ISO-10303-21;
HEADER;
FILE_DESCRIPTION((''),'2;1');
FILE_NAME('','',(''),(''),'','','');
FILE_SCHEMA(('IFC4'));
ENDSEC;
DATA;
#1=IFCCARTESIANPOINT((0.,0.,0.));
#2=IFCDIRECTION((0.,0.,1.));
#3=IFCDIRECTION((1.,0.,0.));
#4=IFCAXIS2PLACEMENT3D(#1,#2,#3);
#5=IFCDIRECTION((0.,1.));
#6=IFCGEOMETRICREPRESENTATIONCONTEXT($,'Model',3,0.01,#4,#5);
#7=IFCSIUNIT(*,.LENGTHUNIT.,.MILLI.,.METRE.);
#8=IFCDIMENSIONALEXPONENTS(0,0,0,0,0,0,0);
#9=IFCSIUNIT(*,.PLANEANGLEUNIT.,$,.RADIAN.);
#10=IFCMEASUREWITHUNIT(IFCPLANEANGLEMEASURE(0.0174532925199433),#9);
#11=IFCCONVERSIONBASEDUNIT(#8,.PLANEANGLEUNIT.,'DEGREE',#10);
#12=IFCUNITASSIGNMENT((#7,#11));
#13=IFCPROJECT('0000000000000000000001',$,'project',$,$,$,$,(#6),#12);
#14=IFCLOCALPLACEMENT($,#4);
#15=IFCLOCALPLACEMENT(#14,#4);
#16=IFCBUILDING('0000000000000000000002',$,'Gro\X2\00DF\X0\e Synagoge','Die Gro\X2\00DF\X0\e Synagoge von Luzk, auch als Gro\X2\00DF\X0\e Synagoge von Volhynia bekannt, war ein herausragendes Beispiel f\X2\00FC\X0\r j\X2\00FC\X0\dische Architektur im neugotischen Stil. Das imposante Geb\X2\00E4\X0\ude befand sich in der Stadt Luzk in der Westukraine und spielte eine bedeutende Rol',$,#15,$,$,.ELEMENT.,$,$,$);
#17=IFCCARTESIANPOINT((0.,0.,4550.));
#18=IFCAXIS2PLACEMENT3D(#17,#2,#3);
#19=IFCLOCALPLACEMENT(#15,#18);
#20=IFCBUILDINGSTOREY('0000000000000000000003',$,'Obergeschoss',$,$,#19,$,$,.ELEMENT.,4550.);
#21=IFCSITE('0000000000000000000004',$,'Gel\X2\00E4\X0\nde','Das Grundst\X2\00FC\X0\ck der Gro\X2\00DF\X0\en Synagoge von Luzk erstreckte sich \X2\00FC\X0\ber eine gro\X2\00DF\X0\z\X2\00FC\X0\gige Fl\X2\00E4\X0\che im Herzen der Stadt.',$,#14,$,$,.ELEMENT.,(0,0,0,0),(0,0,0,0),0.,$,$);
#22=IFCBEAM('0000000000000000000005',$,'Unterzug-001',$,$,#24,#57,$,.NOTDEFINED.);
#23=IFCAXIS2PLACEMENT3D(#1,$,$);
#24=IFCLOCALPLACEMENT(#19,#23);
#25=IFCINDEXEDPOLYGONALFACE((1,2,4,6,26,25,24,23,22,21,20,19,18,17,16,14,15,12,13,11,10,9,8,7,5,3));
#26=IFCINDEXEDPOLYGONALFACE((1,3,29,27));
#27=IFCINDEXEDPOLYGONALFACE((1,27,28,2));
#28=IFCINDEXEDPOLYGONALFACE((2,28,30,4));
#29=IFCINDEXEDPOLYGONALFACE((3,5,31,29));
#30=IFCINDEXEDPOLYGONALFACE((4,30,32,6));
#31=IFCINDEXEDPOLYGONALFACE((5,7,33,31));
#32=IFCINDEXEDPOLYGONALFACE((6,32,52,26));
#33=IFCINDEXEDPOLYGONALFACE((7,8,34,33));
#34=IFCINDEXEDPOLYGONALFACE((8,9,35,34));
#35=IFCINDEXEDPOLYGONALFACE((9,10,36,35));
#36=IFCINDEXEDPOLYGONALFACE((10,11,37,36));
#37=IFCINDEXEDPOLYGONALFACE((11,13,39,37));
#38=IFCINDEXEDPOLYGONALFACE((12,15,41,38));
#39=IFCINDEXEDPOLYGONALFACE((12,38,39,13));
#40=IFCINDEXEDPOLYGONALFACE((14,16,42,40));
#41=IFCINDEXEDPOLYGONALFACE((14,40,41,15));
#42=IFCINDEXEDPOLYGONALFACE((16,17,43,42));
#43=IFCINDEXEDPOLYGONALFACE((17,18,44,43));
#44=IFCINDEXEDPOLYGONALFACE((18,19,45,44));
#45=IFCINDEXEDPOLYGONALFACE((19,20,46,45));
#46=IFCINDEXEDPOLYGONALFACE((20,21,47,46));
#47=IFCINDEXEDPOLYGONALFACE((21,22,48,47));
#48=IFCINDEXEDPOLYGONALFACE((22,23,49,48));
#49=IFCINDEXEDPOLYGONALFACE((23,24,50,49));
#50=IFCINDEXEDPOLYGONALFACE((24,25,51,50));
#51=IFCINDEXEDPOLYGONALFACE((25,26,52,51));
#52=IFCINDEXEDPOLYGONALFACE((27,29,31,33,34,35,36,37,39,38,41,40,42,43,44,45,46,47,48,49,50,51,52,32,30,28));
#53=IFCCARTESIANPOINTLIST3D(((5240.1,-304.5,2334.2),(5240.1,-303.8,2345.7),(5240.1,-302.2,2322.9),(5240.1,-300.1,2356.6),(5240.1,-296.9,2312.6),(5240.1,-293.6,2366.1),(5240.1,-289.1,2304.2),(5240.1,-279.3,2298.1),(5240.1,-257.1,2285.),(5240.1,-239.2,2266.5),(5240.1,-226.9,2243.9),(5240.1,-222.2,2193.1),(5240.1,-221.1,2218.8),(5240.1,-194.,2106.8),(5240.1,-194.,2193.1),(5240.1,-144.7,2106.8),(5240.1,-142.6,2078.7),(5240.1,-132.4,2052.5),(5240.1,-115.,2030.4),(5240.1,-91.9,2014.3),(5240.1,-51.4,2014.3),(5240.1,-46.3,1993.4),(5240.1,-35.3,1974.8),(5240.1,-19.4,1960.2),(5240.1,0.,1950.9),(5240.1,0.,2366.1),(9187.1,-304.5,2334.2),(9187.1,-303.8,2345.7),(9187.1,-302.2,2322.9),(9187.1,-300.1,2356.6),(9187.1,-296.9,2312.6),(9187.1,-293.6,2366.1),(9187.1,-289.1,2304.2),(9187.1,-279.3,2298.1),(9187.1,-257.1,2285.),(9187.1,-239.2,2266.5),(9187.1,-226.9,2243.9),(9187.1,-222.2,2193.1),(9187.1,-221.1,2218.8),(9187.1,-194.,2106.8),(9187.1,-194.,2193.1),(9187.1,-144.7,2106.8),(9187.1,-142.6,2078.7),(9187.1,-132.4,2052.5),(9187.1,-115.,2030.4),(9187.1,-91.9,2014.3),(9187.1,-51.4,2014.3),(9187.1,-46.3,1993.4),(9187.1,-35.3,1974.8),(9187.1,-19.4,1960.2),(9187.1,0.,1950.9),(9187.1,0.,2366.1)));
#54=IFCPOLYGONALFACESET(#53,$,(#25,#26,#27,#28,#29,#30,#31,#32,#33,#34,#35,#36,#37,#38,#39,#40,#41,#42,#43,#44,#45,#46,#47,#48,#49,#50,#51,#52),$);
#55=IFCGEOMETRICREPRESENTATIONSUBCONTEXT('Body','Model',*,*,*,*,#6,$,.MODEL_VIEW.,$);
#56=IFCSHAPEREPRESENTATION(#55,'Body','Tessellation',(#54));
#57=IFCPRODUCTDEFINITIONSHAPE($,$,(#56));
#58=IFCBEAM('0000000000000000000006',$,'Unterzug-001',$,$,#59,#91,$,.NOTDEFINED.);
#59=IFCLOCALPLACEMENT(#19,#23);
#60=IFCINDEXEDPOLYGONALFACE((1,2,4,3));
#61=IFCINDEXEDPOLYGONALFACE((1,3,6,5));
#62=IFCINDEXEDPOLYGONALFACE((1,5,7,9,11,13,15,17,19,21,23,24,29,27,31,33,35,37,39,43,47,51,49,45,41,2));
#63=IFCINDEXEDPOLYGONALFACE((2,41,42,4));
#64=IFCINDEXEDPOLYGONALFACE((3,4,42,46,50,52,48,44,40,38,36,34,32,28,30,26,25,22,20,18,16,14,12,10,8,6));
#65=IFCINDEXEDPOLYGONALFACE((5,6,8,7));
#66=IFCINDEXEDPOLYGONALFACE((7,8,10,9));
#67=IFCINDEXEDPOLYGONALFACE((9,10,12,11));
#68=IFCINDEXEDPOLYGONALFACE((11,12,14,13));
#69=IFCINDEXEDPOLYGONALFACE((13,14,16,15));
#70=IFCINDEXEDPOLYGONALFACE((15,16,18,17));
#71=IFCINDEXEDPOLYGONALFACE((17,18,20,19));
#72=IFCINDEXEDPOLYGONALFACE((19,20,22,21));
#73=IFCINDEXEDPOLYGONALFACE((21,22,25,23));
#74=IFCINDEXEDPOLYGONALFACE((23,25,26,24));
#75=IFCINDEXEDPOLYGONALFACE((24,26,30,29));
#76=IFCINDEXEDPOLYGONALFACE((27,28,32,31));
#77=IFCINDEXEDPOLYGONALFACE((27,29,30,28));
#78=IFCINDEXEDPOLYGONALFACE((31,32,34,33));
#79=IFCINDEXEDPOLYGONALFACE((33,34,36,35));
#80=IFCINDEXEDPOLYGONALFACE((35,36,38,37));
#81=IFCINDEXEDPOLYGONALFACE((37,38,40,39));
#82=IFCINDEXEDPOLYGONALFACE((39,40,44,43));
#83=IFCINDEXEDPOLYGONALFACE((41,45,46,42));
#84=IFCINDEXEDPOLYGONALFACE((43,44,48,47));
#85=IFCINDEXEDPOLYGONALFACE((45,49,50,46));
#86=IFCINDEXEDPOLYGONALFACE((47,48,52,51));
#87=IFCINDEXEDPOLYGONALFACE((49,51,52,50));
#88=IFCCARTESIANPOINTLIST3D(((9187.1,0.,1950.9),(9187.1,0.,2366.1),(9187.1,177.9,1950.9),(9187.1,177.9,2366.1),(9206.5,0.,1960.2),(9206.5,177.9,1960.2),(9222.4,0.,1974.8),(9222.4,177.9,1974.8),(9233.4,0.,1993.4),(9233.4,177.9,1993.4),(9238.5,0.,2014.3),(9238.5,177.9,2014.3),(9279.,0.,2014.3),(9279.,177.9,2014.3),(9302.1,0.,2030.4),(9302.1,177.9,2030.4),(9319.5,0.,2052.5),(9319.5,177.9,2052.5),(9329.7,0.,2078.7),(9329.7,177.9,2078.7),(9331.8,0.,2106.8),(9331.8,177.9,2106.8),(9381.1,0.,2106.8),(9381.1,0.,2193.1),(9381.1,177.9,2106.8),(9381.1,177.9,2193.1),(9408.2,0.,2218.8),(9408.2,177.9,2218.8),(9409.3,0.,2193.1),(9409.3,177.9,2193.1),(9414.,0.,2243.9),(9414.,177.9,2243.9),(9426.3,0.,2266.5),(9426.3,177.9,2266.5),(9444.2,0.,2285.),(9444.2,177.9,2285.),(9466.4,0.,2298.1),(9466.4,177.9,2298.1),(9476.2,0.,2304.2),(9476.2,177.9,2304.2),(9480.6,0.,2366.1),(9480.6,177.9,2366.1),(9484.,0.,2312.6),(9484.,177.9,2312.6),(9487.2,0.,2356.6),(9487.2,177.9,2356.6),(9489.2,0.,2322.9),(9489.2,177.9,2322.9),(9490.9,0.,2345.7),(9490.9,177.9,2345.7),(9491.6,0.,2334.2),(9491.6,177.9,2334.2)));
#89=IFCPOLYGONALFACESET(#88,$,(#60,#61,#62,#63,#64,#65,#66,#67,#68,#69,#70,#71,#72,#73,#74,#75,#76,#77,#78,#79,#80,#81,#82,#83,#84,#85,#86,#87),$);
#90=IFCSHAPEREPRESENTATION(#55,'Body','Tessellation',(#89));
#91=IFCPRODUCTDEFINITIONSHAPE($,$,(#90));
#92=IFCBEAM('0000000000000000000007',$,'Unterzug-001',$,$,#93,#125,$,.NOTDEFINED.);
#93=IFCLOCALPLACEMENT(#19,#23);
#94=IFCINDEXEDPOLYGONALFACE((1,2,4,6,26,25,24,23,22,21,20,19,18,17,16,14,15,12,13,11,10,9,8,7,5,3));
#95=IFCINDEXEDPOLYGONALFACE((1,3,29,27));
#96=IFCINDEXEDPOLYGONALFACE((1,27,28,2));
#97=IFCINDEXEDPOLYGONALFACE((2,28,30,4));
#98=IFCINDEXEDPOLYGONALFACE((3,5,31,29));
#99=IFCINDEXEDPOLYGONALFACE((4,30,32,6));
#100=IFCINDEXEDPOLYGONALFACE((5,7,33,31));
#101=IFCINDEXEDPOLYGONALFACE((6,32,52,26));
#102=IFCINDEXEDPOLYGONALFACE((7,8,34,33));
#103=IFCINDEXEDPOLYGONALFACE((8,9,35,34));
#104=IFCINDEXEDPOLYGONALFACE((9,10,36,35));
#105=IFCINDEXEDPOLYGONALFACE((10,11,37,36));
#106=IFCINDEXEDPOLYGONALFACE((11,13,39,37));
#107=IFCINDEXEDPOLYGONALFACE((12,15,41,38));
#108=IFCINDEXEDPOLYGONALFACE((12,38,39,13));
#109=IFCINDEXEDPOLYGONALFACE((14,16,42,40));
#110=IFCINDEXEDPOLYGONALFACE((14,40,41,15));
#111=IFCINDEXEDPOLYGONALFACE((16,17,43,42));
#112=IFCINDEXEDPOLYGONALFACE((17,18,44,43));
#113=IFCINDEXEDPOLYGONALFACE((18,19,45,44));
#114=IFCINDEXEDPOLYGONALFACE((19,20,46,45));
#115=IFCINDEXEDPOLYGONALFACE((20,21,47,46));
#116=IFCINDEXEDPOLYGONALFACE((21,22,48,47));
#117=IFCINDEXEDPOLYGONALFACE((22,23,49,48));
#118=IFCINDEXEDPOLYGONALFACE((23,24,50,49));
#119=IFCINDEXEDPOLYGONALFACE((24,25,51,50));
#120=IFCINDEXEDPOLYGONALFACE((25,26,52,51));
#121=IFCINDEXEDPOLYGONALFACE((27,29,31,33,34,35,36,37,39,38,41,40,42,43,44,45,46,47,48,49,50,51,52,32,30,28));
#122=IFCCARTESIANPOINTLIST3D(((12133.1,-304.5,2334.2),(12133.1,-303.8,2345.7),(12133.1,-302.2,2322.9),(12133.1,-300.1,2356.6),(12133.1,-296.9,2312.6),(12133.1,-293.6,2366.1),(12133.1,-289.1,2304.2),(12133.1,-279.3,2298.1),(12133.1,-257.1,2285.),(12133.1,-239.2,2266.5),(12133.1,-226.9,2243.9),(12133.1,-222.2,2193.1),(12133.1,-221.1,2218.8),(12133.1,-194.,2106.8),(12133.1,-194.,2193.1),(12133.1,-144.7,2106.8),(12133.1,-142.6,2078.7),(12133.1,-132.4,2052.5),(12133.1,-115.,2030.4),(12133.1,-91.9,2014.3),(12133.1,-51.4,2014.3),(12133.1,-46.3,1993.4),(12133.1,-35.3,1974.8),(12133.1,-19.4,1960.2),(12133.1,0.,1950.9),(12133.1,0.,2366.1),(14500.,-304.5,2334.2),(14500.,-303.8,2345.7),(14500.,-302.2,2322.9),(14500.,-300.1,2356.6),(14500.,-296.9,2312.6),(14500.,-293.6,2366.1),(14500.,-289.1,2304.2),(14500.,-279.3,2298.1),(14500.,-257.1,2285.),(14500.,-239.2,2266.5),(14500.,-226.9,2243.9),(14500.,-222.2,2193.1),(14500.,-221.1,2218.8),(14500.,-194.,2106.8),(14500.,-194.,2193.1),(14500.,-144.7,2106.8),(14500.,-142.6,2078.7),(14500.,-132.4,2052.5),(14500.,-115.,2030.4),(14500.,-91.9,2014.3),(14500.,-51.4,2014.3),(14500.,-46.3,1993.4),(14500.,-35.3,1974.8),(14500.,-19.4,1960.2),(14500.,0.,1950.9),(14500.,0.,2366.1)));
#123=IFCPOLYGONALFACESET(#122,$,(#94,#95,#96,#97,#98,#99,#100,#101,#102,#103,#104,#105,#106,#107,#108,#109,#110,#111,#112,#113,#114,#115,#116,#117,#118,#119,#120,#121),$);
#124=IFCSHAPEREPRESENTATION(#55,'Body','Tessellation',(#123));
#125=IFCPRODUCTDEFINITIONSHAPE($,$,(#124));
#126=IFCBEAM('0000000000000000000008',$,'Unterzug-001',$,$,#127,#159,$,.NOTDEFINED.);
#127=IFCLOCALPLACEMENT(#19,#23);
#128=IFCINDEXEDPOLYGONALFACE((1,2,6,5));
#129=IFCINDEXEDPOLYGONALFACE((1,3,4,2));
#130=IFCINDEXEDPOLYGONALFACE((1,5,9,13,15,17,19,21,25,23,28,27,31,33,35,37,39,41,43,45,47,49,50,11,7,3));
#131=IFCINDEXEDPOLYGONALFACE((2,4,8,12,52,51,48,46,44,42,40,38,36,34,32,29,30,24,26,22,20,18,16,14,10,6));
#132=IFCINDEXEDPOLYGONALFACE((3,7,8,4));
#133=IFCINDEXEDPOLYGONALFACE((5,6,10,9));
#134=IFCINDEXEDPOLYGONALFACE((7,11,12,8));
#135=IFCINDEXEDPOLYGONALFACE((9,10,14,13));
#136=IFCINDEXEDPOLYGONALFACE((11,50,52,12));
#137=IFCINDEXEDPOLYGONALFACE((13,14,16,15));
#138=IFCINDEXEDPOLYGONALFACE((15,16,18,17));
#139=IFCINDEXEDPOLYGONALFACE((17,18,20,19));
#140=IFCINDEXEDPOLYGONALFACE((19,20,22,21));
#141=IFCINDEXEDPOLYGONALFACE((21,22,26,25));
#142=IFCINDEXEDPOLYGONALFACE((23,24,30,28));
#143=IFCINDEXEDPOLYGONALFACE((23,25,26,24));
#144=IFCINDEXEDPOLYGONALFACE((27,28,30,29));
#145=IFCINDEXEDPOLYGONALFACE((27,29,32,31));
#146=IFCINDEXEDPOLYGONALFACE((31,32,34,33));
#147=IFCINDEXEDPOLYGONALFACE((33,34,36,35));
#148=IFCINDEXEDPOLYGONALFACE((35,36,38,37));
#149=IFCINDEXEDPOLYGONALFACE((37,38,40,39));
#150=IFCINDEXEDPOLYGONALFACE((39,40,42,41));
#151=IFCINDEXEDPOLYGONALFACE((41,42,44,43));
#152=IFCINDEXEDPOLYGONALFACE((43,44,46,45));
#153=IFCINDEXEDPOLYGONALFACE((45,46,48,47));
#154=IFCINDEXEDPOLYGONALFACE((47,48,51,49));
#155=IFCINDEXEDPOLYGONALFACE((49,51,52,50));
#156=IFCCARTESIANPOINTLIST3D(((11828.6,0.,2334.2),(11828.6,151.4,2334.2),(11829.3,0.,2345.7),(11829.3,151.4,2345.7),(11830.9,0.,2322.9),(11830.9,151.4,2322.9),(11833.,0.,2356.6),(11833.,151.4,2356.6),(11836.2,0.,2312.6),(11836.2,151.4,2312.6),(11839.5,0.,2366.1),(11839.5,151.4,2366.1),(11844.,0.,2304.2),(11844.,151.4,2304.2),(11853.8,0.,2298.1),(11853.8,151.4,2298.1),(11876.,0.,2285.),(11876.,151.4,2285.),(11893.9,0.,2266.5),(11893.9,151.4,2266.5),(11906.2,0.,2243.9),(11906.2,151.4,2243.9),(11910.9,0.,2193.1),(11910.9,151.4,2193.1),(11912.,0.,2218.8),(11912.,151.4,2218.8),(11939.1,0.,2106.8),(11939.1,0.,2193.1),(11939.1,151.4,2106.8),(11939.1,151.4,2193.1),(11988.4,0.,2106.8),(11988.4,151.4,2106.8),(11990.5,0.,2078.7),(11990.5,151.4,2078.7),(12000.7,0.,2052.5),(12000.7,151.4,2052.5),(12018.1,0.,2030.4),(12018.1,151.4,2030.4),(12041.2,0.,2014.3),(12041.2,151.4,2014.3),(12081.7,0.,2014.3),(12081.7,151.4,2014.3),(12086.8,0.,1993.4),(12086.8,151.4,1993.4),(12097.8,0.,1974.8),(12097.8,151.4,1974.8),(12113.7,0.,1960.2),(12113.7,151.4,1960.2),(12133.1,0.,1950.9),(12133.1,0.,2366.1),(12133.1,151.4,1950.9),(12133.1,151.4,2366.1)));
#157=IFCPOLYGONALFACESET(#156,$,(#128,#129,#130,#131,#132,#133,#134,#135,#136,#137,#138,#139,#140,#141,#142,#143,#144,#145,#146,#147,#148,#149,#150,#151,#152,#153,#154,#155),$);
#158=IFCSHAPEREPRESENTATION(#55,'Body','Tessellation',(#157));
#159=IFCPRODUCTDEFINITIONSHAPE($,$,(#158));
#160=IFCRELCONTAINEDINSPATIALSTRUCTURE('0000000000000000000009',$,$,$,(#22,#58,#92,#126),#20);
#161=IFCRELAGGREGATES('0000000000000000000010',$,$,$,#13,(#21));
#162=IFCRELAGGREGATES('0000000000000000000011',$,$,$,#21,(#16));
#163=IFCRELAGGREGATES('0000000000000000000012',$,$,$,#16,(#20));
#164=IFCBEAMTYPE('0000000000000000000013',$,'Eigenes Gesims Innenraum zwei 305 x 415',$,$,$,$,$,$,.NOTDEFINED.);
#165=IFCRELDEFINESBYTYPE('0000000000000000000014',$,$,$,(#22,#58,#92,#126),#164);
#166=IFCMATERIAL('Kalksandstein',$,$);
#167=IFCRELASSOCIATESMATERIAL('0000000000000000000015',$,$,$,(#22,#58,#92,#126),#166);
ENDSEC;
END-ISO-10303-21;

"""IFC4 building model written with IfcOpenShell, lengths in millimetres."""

from ifc_helpers import new_model, entity, si_unit, converted_unit, direction, frame, origin_with_axes, place, context, subcontext, project, spatial, line, arc, indexed_curve, outline, extrude, material, material_profile, profile_set, type_object, element, save


model = new_model("IFC4")

# Units and contexts
model_context = context("Model", 3, precision=0.01, world=origin_with_axes(), true_north=direction((0.0, 1.0)))
body_context = subcontext(model_context, "Body", "Model", "MODEL_VIEW")
ifc_project = project(units=[si_unit("LENGTHUNIT", "METRE", prefix="MILLI"), converted_unit("PLANEANGLEUNIT", "DEGREE", entity("IfcPlaneAngleMeasure", 0.0174532925199433), si_unit("PLANEANGLEUNIT", "RADIAN"), dimensions=[0, 0, 0, 0, 0, 0, 0])], contexts=[model_context])

# Site, building, storey
site_placement = place(None, origin_with_axes())
site = spatial("IfcSite", under=ifc_project, at=site_placement, Name="Gelände", Description="Das Grundstück der Großen Synagoge von Luzk erstreckte sich über eine großzügige Fläche im Herzen der Stadt.", CompositionType="ELEMENT", RefLatitude=(0, 0, 0, 0), RefLongitude=(0, 0, 0, 0), RefElevation=0.0)
building_placement = place(site_placement, origin_with_axes())
building = spatial("IfcBuilding", under=site, at=building_placement, Name="Große Synagoge", Description="Die Große Synagoge von Luzk, auch als Große Synagoge von Volhynia bekannt, war ein herausragendes Beispiel für jüdische Architektur im neugotischen Stil. Das imposante Gebäude befand sich in der Stadt Luzk in der Westukraine und spielte eine bedeutende Rol", CompositionType="ELEMENT")
storey_placement = place(building_placement, frame((0.0, 0.0, 4550.0), z_axis=(0.0, 0.0, 1.0), x_axis=(1.0, 0.0, 0.0)))
storey = spatial("IfcBuildingStorey", under=building, at=storey_placement, Name="Obergeschoss", CompositionType="ELEMENT", Elevation=4550.0)

# Beams
ifc_material_1 = material(Name="Kalksandstein")
ifc_material_profile_1 = material_profile(ifc_material_1, outline(indexed_curve([(194.0, -173.0), (222.2, -173.0), (232.3, -110.5), (279.3, -68.0), (303.7, -37.6), (293.6, 0.0), (0.0, 0.0), (0.0, -415.2), (35.3, -391.3), (51.4, -351.7), (91.9, -351.7), (132.4, -313.6), (144.7, -259.3), (194.0, -259.3)], segments=[line(1, 2), arc(2, 3, 4), arc(4, 5, 6), line(6, 7, 8), arc(8, 9, 10), line(10, 11), arc(11, 12, 13), line(13, 14, 1)])), Name="Kalksandstein")
ifc_profile_set_1 = profile_set([ifc_material_profile_1], Name="Eigenes Gesims Innenraum zwei")
beam_type_1 = type_object("IfcBeamType", Name="Eigenes Gesims Innenraum zwei 305 x 415", PredefinedType="NOTDEFINED")
beam_1_placement = place(storey_placement, frame((9187.1, 0.0, 2366.1), z_axis=(0.0, 0.0, 1.0), x_axis=(0.0, 1.0, 0.0)))
element("IfcBeam", 1, at=beam_1_placement, inside=storey, type_object=beam_type_1, material=ifc_profile_set_1, Name="Unterzug-001", PredefinedType="NOTDEFINED", context=body_context, shape_type="SweptSolid", body=[
    extrude(outline(indexed_curve([(194.0, -173.0), (222.2, -173.0), (232.3, -110.5), (279.3, -68.0), (303.7, -37.6), (293.6, 0.0), (0.0, 0.0), (0.0, -415.2), (35.3, -391.3), (51.4, -351.7), (91.9, -351.7), (132.4, -313.6), (144.7, -259.3), (194.0, -259.3)], segments=[line(1, 2), arc(2, 3, 4), arc(4, 5, 6), line(6, 7, 8), arc(8, 9, 10), line(10, 11), arc(11, 12, 13), line(13, 14, 1)])), frame((0.0, 3947.0, 0.0), z_axis=(0.0, 1.0, 0.0), x_axis=(-1.0, 0.0, 0.0)), (0.0, 0.0, -1.0), 3947.0),
])
beam_2_placement = place(storey_placement, frame((9187.1, 177.9, 2366.1), z_axis=(0.0, 0.0, 1.0), x_axis=(-1.0, 0.0, 0.0)))
element("IfcBeam", 2, at=beam_2_placement, inside=storey, type_object=beam_type_1, material=ifc_profile_set_1, Name="Unterzug-001", PredefinedType="NOTDEFINED", context=body_context, shape_type="SweptSolid", body=[
    extrude(outline(indexed_curve([(194.0, -173.0), (222.2, -173.0), (232.3, -110.5), (279.3, -68.0), (303.7, -37.6), (293.6, 0.0), (0.0, 0.0), (0.0, -415.2), (35.3, -391.3), (51.4, -351.7), (91.9, -351.7), (132.4, -313.6), (144.7, -259.3), (194.0, -259.3)], segments=[line(1, 2), arc(2, 3, 4), arc(4, 5, 6), line(6, 7, 8), arc(8, 9, 10), line(10, 11), arc(11, 12, 13), line(13, 14, 1)])), frame((0.0, 177.9, 0.0), z_axis=(0.0, 1.0, 0.0), x_axis=(-1.0, 0.0, 0.0)), (0.0, 0.0, -1.0), 177.9),
])
beam_3_placement = place(storey_placement, frame((14500.0, 0.0, 2366.1), z_axis=(0.0, 0.0, 1.0), x_axis=(0.0, 1.0, 0.0)))
element("IfcBeam", 3, at=beam_3_placement, inside=storey, type_object=beam_type_1, material=ifc_profile_set_1, Name="Unterzug-001", PredefinedType="NOTDEFINED", context=body_context, shape_type="SweptSolid", body=[
    extrude(outline(indexed_curve([(194.0, -173.0), (222.2, -173.0), (232.3, -110.5), (279.3, -68.0), (303.7, -37.6), (293.6, 0.0), (0.0, 0.0), (0.0, -415.2), (35.3, -391.3), (51.4, -351.7), (91.9, -351.7), (132.4, -313.6), (144.7, -259.3), (194.0, -259.3)], segments=[line(1, 2), arc(2, 3, 4), arc(4, 5, 6), line(6, 7, 8), arc(8, 9, 10), line(10, 11), arc(11, 12, 13), line(13, 14, 1)])), frame((0.0, 2366.9, 0.0), z_axis=(0.0, 1.0, 0.0), x_axis=(-1.0, 0.0, 0.0)), (0.0, 0.0, -1.0), 2366.9),
])
beam_4_placement = place(storey_placement, frame((12133.1, 0.0, 2366.1), z_axis=(0.0, 0.0, 1.0), x_axis=(1.0, 0.0, 0.0)))
element("IfcBeam", 4, at=beam_4_placement, inside=storey, type_object=beam_type_1, material=ifc_profile_set_1, Name="Unterzug-001", PredefinedType="NOTDEFINED", context=body_context, shape_type="SweptSolid", body=[
    extrude(outline(indexed_curve([(194.0, -173.0), (222.2, -173.0), (232.3, -110.5), (279.3, -68.0), (303.7, -37.6), (293.6, 0.0), (0.0, 0.0), (0.0, -415.2), (35.3, -391.3), (51.4, -351.7), (91.9, -351.7), (132.4, -313.6), (144.7, -259.3), (194.0, -259.3)], segments=[line(1, 2), arc(2, 3, 4), arc(4, 5, 6), line(6, 7, 8), arc(8, 9, 10), line(10, 11), arc(11, 12, 13), line(13, 14, 1)])), frame((0.0, 151.4, 0.0), z_axis=(0.0, 1.0, 0.0), x_axis=(-1.0, 0.0, 0.0)), (0.0, 0.0, -1.0), 151.4),
])

save(model, "model.ifc")
